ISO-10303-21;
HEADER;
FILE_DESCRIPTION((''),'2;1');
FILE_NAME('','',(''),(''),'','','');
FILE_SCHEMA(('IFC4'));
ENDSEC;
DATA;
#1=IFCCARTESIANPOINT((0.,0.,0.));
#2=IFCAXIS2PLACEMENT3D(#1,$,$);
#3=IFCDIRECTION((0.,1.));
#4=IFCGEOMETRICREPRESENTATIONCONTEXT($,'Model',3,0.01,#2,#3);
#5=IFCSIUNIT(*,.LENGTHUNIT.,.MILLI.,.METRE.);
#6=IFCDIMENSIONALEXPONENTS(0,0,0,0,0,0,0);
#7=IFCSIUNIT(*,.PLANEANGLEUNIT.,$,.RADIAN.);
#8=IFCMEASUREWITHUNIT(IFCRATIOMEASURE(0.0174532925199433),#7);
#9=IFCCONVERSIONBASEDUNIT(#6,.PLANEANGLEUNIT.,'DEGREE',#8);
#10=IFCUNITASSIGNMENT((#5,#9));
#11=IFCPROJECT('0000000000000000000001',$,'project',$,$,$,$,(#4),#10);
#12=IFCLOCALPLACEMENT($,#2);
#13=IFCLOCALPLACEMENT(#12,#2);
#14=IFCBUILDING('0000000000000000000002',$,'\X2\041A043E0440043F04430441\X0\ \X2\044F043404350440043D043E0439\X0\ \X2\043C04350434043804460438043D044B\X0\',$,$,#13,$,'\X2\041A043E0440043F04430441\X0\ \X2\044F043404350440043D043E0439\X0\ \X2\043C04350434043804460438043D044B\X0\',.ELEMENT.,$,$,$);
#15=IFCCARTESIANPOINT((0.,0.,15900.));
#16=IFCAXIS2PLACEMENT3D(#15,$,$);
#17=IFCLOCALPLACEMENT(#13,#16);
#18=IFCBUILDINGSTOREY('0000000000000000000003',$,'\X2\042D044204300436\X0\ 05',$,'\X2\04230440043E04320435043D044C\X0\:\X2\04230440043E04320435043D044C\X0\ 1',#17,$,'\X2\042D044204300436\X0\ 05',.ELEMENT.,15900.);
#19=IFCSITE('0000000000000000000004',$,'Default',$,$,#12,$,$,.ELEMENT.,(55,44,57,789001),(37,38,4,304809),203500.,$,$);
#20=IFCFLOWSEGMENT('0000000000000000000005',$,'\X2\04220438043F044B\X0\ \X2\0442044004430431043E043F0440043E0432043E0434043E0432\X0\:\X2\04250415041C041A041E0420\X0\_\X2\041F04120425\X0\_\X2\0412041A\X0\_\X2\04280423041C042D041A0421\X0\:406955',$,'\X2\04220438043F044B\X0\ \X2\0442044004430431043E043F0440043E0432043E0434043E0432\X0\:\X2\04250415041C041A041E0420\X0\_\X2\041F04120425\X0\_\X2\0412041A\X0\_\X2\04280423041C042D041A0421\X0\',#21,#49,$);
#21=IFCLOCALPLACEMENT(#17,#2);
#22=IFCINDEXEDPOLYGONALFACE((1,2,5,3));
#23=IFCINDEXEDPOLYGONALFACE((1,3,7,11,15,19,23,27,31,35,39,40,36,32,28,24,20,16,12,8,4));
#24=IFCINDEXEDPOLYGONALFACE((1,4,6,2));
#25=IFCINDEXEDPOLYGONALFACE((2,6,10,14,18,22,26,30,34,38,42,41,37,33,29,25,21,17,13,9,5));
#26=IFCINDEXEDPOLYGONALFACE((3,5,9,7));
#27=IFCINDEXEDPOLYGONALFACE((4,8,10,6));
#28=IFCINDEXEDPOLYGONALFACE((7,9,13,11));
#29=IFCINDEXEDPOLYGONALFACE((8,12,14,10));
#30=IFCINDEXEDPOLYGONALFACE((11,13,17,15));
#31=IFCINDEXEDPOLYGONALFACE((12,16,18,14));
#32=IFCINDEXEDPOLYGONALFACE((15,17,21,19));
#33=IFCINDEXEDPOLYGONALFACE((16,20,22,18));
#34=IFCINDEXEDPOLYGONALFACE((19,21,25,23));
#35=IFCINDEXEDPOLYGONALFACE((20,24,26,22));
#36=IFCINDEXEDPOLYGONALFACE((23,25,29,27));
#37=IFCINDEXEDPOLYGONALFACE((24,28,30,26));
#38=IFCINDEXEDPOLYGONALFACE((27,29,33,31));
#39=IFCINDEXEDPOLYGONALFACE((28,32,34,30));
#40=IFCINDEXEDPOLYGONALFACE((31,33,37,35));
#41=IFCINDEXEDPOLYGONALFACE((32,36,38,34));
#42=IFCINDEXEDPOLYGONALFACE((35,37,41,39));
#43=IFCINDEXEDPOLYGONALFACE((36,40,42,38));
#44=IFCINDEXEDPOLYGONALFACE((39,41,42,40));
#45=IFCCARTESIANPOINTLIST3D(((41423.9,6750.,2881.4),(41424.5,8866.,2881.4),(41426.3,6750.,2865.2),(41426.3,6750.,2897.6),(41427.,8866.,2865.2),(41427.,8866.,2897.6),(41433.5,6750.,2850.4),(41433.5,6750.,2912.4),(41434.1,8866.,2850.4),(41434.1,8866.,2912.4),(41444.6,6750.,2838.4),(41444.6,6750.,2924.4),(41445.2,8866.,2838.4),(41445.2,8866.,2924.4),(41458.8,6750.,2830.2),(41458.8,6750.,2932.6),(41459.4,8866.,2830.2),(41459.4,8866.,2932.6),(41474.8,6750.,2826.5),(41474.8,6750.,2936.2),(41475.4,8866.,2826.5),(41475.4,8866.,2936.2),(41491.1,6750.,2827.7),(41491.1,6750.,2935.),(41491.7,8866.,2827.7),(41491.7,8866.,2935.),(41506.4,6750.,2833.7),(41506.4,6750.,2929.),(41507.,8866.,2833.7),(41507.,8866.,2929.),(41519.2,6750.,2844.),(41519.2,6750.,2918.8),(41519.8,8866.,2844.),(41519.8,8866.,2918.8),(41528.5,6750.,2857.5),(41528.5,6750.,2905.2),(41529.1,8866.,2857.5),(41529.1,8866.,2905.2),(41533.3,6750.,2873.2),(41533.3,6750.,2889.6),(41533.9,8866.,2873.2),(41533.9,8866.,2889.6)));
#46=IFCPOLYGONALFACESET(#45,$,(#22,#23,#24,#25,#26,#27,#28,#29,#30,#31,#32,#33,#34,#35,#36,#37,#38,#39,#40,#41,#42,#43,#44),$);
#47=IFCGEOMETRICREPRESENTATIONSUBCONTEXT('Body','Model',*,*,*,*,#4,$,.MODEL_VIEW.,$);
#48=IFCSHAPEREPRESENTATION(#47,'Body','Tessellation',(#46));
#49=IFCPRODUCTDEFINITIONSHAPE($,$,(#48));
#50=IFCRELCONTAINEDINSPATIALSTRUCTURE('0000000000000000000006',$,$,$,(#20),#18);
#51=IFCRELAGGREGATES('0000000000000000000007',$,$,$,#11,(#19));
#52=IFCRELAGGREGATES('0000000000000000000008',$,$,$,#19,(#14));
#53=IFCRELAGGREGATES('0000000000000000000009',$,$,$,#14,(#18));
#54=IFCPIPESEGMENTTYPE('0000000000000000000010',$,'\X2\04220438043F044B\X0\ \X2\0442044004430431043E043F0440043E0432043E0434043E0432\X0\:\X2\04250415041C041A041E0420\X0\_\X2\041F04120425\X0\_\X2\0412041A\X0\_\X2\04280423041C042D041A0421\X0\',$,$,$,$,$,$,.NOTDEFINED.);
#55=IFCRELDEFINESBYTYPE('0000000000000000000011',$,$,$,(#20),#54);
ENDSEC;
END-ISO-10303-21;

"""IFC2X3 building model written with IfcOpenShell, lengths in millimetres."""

from ifc_helpers import new_model, entity, si_unit, converted_unit, direction, frame, origin, origin_2d_with_axis, place, context, subcontext, project, spatial, circle, extrude, type_object, element, save


model = new_model("IFC2X3")

# Units and contexts
model_context = context("Model", 3, precision=0.01, world=origin(), true_north=direction((0.0, 1.0)))
body_context = subcontext(model_context, "Body", "Model", "MODEL_VIEW")
ifc_project = project(units=[si_unit("LENGTHUNIT", "METRE", prefix="MILLI"), converted_unit("PLANEANGLEUNIT", "DEGREE", entity("IfcRatioMeasure", 0.0174532925199433), si_unit("PLANEANGLEUNIT", "RADIAN"), dimensions=[0, 0, 0, 0, 0, 0, 0])], contexts=[model_context])

# Site, building, storey
site_placement = place(None, origin())
site = spatial("IfcSite", under=ifc_project, at=site_placement, Name="Default", CompositionType="ELEMENT", RefLatitude=(55, 44, 57, 789001), RefLongitude=(37, 38, 4, 304809), RefElevation=203500.0)
building_placement = place(site_placement, origin())
building = spatial("IfcBuilding", under=site, at=building_placement, Name="Корпус ядерной медицины", LongName="Корпус ядерной медицины", CompositionType="ELEMENT")
storey_placement = place(building_placement, frame((0.0, 0.0, 15900.0)))
storey = spatial("IfcBuildingStorey", under=building, at=storey_placement, Name="Этаж 05", ObjectType="Уровень:Уровень 1", LongName="Этаж 05", CompositionType="ELEMENT", Elevation=15900.0)

# Flow segment
pipe_segment_type = type_object("IfcPipeSegmentType", Name="Типы трубопроводов:ХЕМКОР_ПВХ_ВК_ШУМЭКС", PredefinedType="NOTDEFINED")
flow_segment_1_placement = place(storey_placement, frame((41422.3, 6750.0, 2824.8)))
element("IfcFlowSegment", 1, at=flow_segment_1_placement, inside=storey, type_object=pipe_segment_type, Name="Типы трубопроводов:ХЕМКОР_ПВХ_ВК_ШУМЭКС:406955", ObjectType="Типы трубопроводов:ХЕМКОР_ПВХ_ВК_ШУМЭКС", context=body_context, shape_type="SweptSolid", body=[
    extrude(circle(Radius=55.0, at=origin_2d_with_axis()), frame((56.6, 0.0, 56.6), z_axis=(0.000289, 1.0, 0.0), x_axis=(-1.0, 0.000289, 0.0)), (0.0, 0.0, 1.0), 2116.0),
])

save(model, "model.ifc")
